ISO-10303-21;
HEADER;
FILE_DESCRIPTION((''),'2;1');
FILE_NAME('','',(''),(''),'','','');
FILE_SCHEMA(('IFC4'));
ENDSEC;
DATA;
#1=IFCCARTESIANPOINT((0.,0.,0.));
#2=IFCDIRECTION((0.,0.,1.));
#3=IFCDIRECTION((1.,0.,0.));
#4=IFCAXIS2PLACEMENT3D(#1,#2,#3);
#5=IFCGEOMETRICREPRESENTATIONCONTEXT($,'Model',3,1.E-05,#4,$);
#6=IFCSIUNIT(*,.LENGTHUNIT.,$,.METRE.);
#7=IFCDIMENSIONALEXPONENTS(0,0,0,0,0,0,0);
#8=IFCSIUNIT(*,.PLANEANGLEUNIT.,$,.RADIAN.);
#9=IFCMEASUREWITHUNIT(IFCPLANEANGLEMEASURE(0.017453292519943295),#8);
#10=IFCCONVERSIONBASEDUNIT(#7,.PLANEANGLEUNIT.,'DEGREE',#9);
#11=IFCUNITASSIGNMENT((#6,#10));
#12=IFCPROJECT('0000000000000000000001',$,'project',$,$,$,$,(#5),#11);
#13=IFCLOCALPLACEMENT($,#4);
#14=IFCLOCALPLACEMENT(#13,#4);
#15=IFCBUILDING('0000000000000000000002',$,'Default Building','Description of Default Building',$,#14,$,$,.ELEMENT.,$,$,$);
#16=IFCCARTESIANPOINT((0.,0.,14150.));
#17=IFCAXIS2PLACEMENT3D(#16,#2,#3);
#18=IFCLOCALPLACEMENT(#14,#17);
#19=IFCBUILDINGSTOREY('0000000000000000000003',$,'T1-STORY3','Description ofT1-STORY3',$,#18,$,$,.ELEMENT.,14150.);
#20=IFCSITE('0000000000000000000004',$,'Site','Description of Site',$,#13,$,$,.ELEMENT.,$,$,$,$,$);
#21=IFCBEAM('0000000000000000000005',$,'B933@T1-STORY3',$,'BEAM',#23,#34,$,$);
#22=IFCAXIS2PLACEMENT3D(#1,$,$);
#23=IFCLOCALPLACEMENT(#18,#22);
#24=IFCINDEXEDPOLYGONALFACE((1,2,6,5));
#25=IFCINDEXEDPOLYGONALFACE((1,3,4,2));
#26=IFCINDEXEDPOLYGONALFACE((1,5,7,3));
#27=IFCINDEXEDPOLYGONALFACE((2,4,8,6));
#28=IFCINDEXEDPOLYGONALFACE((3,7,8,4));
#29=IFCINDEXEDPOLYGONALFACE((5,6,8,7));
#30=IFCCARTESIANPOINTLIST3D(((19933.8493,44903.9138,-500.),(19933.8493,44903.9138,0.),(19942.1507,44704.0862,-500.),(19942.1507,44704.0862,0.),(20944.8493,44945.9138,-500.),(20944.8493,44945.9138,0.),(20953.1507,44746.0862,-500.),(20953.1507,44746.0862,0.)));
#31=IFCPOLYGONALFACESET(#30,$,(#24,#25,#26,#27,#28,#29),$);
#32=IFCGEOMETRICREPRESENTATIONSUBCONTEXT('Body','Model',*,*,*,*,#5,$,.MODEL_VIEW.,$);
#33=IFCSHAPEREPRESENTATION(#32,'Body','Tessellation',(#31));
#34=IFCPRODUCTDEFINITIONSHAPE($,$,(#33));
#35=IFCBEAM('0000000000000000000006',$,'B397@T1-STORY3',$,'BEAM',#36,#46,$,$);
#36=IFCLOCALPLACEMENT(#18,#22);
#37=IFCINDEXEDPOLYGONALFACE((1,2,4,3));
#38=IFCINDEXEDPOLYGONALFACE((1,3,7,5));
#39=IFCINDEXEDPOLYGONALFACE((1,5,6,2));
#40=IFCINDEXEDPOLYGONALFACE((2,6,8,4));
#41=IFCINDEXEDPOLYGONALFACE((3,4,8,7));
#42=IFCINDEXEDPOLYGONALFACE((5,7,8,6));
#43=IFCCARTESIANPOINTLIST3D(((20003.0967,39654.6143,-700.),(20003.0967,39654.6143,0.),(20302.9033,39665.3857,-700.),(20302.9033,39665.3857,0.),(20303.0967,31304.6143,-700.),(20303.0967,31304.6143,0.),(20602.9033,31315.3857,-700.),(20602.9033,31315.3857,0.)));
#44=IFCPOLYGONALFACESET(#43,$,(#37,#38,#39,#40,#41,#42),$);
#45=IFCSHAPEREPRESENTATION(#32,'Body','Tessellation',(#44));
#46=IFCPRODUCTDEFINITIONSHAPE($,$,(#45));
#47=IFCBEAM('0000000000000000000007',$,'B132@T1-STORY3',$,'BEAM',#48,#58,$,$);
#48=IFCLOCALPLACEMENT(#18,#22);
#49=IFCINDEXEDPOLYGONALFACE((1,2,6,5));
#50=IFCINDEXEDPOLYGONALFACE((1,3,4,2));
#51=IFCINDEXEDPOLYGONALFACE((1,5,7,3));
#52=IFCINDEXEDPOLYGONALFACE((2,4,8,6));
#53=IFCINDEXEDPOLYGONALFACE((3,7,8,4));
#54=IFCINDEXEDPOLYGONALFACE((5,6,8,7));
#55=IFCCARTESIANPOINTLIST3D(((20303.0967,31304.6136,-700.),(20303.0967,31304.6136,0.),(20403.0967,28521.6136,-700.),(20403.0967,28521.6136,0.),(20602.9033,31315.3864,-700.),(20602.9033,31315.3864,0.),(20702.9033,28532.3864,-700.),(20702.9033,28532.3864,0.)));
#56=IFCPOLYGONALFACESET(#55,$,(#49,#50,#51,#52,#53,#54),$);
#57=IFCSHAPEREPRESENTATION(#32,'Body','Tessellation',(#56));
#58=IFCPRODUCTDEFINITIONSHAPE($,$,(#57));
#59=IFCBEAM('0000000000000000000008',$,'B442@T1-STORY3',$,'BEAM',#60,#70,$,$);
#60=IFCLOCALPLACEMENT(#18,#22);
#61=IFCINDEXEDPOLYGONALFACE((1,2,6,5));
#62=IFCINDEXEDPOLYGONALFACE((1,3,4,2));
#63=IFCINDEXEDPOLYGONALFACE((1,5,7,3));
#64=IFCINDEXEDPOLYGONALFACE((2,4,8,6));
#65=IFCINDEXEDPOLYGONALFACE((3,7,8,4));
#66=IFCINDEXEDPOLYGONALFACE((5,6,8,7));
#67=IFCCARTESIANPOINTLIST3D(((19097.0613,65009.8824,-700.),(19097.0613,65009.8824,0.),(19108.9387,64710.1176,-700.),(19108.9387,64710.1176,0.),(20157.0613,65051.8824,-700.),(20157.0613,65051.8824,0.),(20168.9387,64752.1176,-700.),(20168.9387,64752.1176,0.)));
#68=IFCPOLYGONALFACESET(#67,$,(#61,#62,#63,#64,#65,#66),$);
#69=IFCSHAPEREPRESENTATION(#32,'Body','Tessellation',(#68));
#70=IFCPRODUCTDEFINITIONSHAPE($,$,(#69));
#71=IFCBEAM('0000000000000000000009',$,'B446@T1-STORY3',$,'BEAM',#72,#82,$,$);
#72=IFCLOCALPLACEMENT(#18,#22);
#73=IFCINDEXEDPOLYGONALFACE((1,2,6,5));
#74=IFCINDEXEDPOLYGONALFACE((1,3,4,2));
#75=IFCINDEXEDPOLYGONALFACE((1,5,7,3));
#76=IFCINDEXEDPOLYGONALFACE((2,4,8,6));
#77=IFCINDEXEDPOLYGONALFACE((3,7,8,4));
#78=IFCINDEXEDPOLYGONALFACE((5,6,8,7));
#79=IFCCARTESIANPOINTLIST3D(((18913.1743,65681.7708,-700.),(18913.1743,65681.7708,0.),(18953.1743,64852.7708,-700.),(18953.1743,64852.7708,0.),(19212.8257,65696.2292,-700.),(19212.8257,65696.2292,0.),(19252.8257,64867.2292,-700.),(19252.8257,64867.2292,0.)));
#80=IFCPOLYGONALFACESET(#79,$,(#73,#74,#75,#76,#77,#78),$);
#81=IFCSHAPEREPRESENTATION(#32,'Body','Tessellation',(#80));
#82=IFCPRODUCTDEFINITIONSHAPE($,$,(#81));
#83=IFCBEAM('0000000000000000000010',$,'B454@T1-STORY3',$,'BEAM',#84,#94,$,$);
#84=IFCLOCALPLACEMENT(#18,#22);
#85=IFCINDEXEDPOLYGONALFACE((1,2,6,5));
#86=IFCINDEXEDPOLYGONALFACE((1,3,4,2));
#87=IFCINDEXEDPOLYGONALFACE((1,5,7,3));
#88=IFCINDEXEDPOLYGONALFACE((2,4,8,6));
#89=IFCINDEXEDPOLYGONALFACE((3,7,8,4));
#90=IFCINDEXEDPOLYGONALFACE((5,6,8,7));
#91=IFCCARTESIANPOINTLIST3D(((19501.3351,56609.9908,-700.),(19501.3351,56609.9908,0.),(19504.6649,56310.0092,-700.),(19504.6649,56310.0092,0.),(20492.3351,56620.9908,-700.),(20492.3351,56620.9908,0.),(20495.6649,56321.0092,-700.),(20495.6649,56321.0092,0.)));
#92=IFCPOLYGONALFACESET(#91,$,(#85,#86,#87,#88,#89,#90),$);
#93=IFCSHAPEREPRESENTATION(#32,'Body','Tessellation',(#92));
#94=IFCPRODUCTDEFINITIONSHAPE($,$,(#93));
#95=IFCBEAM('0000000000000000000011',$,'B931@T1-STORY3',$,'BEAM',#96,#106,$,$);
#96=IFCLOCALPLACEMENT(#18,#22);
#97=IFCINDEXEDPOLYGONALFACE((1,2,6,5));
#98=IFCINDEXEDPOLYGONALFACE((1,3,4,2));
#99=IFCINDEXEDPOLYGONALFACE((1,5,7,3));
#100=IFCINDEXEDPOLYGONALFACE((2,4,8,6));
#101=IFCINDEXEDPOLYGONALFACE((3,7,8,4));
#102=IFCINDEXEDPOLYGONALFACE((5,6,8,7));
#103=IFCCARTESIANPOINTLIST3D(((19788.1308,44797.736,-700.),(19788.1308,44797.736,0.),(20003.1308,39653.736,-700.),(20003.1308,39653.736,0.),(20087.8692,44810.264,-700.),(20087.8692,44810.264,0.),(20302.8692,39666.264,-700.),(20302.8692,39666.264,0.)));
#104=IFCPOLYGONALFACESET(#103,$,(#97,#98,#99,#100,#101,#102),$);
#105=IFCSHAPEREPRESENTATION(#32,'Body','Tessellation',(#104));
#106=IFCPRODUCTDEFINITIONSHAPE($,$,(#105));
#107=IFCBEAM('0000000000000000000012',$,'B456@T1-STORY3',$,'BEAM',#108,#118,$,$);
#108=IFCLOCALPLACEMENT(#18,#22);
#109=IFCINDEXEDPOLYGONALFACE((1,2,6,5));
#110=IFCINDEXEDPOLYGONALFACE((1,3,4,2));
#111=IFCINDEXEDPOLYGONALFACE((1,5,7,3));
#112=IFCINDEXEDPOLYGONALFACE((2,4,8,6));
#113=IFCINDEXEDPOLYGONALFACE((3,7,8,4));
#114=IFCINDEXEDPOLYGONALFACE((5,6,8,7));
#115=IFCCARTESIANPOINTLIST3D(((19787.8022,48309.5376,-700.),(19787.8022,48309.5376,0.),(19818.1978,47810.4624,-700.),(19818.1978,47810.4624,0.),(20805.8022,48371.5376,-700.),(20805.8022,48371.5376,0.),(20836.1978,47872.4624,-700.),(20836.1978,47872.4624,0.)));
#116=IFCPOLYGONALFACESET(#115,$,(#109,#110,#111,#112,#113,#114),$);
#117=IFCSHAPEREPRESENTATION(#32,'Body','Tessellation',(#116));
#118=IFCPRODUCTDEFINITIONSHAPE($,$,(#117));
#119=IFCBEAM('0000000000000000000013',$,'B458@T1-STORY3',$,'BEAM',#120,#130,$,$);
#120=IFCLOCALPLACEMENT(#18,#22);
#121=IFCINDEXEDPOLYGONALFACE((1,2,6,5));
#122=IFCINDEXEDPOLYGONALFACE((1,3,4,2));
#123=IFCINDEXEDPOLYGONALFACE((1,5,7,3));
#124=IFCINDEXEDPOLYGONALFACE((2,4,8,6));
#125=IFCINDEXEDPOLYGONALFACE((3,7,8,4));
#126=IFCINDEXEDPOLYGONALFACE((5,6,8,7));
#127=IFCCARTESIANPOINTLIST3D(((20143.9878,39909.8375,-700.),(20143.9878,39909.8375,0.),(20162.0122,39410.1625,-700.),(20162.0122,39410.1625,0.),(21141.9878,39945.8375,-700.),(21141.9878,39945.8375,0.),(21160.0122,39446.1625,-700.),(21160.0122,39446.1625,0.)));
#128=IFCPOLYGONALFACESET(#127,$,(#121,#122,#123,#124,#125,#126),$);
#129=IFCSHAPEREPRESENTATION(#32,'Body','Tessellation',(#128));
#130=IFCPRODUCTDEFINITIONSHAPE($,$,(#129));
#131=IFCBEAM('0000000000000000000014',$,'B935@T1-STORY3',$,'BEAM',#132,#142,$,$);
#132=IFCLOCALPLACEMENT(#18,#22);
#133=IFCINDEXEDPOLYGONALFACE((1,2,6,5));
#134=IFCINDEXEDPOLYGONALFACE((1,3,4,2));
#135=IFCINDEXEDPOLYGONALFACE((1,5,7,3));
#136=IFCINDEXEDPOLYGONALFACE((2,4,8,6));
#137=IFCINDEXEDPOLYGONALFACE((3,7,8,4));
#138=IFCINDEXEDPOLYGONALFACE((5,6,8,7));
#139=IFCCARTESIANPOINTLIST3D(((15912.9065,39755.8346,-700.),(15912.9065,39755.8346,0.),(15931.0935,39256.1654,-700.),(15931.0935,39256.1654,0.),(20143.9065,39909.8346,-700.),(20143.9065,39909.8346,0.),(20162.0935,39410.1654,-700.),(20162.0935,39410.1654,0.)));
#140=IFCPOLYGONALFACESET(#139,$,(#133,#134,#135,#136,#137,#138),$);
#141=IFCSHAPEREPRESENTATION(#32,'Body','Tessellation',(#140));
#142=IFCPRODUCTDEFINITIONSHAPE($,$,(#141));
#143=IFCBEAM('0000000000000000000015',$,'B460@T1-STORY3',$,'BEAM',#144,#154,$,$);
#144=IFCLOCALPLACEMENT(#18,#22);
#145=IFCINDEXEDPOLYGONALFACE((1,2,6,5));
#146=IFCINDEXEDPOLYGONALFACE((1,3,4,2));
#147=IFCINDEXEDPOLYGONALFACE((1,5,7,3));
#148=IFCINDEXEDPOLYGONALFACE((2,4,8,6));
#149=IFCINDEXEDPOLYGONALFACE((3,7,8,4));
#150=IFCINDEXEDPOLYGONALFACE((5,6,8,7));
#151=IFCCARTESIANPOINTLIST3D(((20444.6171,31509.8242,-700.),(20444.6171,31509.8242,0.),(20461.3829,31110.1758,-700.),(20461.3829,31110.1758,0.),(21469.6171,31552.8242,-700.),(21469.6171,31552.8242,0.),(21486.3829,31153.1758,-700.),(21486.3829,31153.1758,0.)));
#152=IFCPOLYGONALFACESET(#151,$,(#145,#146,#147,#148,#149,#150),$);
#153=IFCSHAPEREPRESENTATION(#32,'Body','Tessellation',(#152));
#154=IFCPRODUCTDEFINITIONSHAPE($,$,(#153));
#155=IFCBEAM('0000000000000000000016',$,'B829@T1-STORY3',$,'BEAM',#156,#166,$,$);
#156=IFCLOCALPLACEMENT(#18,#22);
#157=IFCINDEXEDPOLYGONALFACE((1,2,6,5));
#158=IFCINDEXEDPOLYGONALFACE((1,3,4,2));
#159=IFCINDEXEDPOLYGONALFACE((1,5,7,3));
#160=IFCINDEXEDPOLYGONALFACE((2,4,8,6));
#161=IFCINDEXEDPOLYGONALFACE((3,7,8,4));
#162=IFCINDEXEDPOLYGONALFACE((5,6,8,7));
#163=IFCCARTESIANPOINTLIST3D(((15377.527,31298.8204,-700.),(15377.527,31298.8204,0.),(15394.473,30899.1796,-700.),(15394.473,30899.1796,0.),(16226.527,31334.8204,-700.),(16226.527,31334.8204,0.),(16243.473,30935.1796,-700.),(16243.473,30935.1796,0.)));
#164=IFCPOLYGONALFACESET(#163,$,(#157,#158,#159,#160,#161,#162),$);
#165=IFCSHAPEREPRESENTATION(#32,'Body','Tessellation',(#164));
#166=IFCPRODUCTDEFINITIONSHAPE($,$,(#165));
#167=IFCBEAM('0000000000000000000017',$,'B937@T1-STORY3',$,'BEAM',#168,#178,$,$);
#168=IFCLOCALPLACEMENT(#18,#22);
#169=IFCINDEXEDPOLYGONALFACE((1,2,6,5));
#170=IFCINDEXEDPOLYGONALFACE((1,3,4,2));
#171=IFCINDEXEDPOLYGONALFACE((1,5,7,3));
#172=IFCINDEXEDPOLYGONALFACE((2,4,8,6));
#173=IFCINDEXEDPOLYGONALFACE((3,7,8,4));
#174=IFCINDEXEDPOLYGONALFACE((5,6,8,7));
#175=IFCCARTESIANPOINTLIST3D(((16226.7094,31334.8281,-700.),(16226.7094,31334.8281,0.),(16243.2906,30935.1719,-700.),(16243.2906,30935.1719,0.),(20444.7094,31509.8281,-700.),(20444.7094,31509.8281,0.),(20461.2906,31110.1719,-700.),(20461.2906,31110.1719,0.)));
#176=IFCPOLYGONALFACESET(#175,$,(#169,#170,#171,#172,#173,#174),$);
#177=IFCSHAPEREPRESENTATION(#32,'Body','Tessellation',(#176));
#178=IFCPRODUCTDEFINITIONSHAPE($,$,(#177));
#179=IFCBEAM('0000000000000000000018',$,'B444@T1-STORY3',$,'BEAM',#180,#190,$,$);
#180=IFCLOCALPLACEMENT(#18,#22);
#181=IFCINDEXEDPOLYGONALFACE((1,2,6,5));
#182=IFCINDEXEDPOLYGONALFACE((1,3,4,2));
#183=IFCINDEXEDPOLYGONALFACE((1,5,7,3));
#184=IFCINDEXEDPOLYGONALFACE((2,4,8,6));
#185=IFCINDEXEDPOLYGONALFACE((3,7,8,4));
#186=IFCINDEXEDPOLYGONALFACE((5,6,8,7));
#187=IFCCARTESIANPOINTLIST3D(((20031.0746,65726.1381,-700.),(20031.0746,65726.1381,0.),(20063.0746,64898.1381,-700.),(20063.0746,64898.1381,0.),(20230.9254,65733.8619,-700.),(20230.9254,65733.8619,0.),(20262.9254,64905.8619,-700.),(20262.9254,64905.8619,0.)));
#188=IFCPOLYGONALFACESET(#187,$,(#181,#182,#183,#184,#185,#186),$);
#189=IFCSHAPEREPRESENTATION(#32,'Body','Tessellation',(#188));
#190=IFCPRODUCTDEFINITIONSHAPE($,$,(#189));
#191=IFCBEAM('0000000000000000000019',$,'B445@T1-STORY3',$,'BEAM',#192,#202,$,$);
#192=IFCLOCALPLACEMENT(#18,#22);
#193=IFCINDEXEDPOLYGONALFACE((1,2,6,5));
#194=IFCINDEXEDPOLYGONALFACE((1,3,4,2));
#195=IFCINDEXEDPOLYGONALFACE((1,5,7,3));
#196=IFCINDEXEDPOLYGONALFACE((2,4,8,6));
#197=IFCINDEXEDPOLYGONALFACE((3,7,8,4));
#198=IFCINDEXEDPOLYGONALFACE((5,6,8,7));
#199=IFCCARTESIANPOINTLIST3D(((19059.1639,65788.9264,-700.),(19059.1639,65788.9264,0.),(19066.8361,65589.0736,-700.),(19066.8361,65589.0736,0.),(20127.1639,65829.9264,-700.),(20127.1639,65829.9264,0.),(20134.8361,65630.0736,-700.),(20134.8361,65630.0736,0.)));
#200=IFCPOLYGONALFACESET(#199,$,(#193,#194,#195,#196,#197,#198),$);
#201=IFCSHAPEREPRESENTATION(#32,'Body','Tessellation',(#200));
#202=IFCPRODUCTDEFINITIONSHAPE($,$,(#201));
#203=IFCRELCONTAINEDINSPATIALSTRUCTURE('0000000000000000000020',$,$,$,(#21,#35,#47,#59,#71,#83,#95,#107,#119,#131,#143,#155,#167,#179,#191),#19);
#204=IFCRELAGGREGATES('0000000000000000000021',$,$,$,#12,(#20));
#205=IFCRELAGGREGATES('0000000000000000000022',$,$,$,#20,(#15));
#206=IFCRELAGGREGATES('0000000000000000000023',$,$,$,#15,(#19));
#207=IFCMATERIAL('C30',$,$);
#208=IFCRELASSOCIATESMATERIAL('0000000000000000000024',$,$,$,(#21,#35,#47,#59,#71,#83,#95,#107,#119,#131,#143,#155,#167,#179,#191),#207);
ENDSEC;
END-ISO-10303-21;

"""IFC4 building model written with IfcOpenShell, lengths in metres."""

from ifc_helpers import new_model, entity, si_unit, converted_unit, frame, origin_with_axes, place, context, subcontext, project, spatial, rectangle, extrude, material, element, save


model = new_model("IFC4")

# Units and contexts
model_context = context("Model", 3, precision=1e-05, world=origin_with_axes())
body_context = subcontext(model_context, "Body", "Model", "MODEL_VIEW")
ifc_project = project(units=[si_unit("LENGTHUNIT", "METRE"), converted_unit("PLANEANGLEUNIT", "DEGREE", entity("IfcPlaneAngleMeasure", 0.017453292519943295), si_unit("PLANEANGLEUNIT", "RADIAN"), dimensions=[0, 0, 0, 0, 0, 0, 0])], contexts=[model_context])

# Site, building, storey
site_placement = place(None, origin_with_axes())
site = spatial("IfcSite", under=ifc_project, at=site_placement, Name="Site", Description="Description of Site", CompositionType="ELEMENT")
building_placement = place(site_placement, origin_with_axes())
building = spatial("IfcBuilding", under=site, at=building_placement, Name="Default Building", Description="Description of Default Building", CompositionType="ELEMENT")
storey_placement = place(building_placement, frame((0.0, 0.0, 14150.0), z_axis=(0.0, 0.0, 1.0), x_axis=(1.0, 0.0, 0.0)))
storey = spatial("IfcBuildingStorey", under=building, at=storey_placement, Name="T1-STORY3", Description="Description ofT1-STORY3", CompositionType="ELEMENT", Elevation=14150.0)

# Beams
ifc_material_1 = material(Name="C30")
beam_1_placement = place(storey_placement, frame((19938.0, 44804.0, -250.0), z_axis=(0.999138, 0.041507, 0.0), x_axis=(-0.041507, 0.999138, 0.0)))
element("IfcBeam", 1, at=beam_1_placement, inside=storey, material=ifc_material_1, Name="B933@T1-STORY3", ObjectType="BEAM", context=body_context, shape_type="SweptSolid", body=[
    extrude(rectangle(XDim=200.0, YDim=500.0), origin_with_axes(), (0.0, 0.0, 1.0), 1011.872),
])
beam_2_placement = place(storey_placement, frame((20153.0, 39660.0, -350.0), z_axis=(0.035905, -0.999355, 0.0), x_axis=(0.999355, 0.035905, 0.0)))
element("IfcBeam", 2, at=beam_2_placement, inside=storey, material=ifc_material_1, Name="B397@T1-STORY3", ObjectType="BEAM", context=body_context, shape_type="SweptSolid", body=[
    extrude(rectangle(XDim=300.0, YDim=700.0), origin_with_axes(), (0.0, 0.0, 1.0), 8355.3875),
])
beam_3_placement = place(storey_placement, frame((20453.0, 31310.0, -350.0), z_axis=(0.035909, -0.999355, 0.0), x_axis=(0.999355, 0.035909, 0.0)))
element("IfcBeam", 3, at=beam_3_placement, inside=storey, material=ifc_material_1, Name="B132@T1-STORY3", ObjectType="BEAM", context=body_context, shape_type="SweptSolid", body=[
    extrude(rectangle(XDim=300.0, YDim=700.0), origin_with_axes(), (0.0, 0.0, 1.0), 2784.796),
])
beam_4_placement = place(storey_placement, frame((19103.0, 64860.0, -350.0), z_axis=(0.999216, 0.039592, 0.0), x_axis=(-0.039592, 0.999216, 0.0)))
element("IfcBeam", 4, at=beam_4_placement, inside=storey, material=ifc_material_1, Name="B442@T1-STORY3", ObjectType="BEAM", context=body_context, shape_type="SweptSolid", body=[
    extrude(rectangle(XDim=300.0, YDim=700.0), origin_with_axes(), (0.0, 0.0, 1.0), 1060.8317),
])
beam_5_placement = place(storey_placement, frame((19063.0, 65689.0, -350.0), z_axis=(0.048195, -0.998838, 0.0), x_axis=(0.998838, 0.048195, 0.0)))
element("IfcBeam", 5, at=beam_5_placement, inside=storey, material=ifc_material_1, Name="B446@T1-STORY3", ObjectType="BEAM", context=body_context, shape_type="SweptSolid", body=[
    extrude(rectangle(XDim=300.0, YDim=700.0), origin_with_axes(), (0.0, 0.0, 1.0), 829.9645),
])
beam_6_placement = place(storey_placement, frame((19503.0, 56460.0, -350.0), z_axis=(0.999938, 0.011099, 0.0), x_axis=(-0.011099, 0.999938, 0.0)))
element("IfcBeam", 6, at=beam_6_placement, inside=storey, material=ifc_material_1, Name="B454@T1-STORY3", ObjectType="BEAM", context=body_context, shape_type="SweptSolid", body=[
    extrude(rectangle(XDim=300.0, YDim=700.0), origin_with_axes(), (0.0, 0.0, 1.0), 991.061),
])
beam_7_placement = place(storey_placement, frame((19938.0, 44804.0, -350.0), z_axis=(0.04176, -0.999128, 0.0), x_axis=(0.999128, 0.04176, 0.0)))
element("IfcBeam", 7, at=beam_7_placement, inside=storey, material=ifc_material_1, Name="B931@T1-STORY3", ObjectType="BEAM", context=body_context, shape_type="SweptSolid", body=[
    extrude(rectangle(XDim=300.0, YDim=700.0), origin_with_axes(), (0.0, 0.0, 1.0), 5148.4911),
])
beam_8_placement = place(storey_placement, frame((19803.0, 48060.0, -350.0), z_axis=(0.998151, 0.060791, 0.0), x_axis=(-0.060791, 0.998151, 0.0)))
element("IfcBeam", 8, at=beam_8_placement, inside=storey, material=ifc_material_1, Name="B456@T1-STORY3", ObjectType="BEAM", context=body_context, shape_type="SweptSolid", body=[
    extrude(rectangle(XDim=500.0, YDim=700.0), origin_with_axes(), (0.0, 0.0, 1.0), 1019.8863),
])
beam_9_placement = place(storey_placement, frame((20153.0, 39660.0, -350.0), z_axis=(0.99935, 0.036049, 0.0), x_axis=(-0.036049, 0.99935, 0.0)))
element("IfcBeam", 9, at=beam_9_placement, inside=storey, material=ifc_material_1, Name="B458@T1-STORY3", ObjectType="BEAM", context=body_context, shape_type="SweptSolid", body=[
    extrude(rectangle(XDim=500.0, YDim=700.0), origin_with_axes(), (0.0, 0.0, 1.0), 998.6491),
])
beam_10_placement = place(storey_placement, frame((15922.0, 39506.0, -350.0), z_axis=(0.999338, 0.036374, 0.0), x_axis=(-0.036374, 0.999338, 0.0)))
element("IfcBeam", 10, at=beam_10_placement, inside=storey, material=ifc_material_1, Name="B935@T1-STORY3", ObjectType="BEAM", context=body_context, shape_type="SweptSolid", body=[
    extrude(rectangle(XDim=500.0, YDim=700.0), origin_with_axes(), (0.0, 0.0, 1.0), 4233.8017),
])
beam_11_placement = place(storey_placement, frame((20453.0, 31310.0, -350.0), z_axis=(0.999121, 0.041914, 0.0), x_axis=(-0.041914, 0.999121, 0.0)))
element("IfcBeam", 11, at=beam_11_placement, inside=storey, material=ifc_material_1, Name="B460@T1-STORY3", ObjectType="BEAM", context=body_context, shape_type="SweptSolid", body=[
    extrude(rectangle(XDim=400.0, YDim=700.0), origin_with_axes(), (0.0, 0.0, 1.0), 1025.9016),
])
beam_12_placement = place(storey_placement, frame((15386.0, 31099.0, -350.0), z_axis=(0.999102, 0.042365, 0.0), x_axis=(-0.042365, 0.999102, 0.0)))
element("IfcBeam", 12, at=beam_12_placement, inside=storey, material=ifc_material_1, Name="B829@T1-STORY3", ObjectType="BEAM", context=body_context, shape_type="SweptSolid", body=[
    extrude(rectangle(XDim=400.0, YDim=700.0), origin_with_axes(), (0.0, 0.0, 1.0), 849.7629),
])
beam_13_placement = place(storey_placement, frame((16235.0, 31135.0, -350.0), z_axis=(0.99914, 0.041453, 0.0), x_axis=(-0.041453, 0.99914, 0.0)))
element("IfcBeam", 13, at=beam_13_placement, inside=storey, material=ifc_material_1, Name="B937@T1-STORY3", ObjectType="BEAM", context=body_context, shape_type="SweptSolid", body=[
    extrude(rectangle(XDim=400.0, YDim=700.0), origin_with_axes(), (0.0, 0.0, 1.0), 4221.6287),
])
beam_14_placement = place(storey_placement, frame((20131.0, 65730.0, -350.0), z_axis=(0.038619, -0.999254, 0.0), x_axis=(0.999254, 0.038619, 0.0)))
element("IfcBeam", 14, at=beam_14_placement, inside=storey, material=ifc_material_1, Name="B444@T1-STORY3", ObjectType="BEAM", context=body_context, shape_type="SweptSolid", body=[
    extrude(rectangle(XDim=200.0, YDim=700.0), origin_with_axes(), (0.0, 0.0, 1.0), 828.6181),
])
beam_15_placement = place(storey_placement, frame((19063.0, 65689.0, -350.0), z_axis=(0.999264, 0.038361, 0.0), x_axis=(-0.038361, 0.999264, 0.0)))
element("IfcBeam", 15, at=beam_15_placement, inside=storey, material=ifc_material_1, Name="B445@T1-STORY3", ObjectType="BEAM", context=body_context, shape_type="SweptSolid", body=[
    extrude(rectangle(XDim=200.0, YDim=700.0), origin_with_axes(), (0.0, 0.0, 1.0), 1068.7867),
])

save(model, "model.ifc")
